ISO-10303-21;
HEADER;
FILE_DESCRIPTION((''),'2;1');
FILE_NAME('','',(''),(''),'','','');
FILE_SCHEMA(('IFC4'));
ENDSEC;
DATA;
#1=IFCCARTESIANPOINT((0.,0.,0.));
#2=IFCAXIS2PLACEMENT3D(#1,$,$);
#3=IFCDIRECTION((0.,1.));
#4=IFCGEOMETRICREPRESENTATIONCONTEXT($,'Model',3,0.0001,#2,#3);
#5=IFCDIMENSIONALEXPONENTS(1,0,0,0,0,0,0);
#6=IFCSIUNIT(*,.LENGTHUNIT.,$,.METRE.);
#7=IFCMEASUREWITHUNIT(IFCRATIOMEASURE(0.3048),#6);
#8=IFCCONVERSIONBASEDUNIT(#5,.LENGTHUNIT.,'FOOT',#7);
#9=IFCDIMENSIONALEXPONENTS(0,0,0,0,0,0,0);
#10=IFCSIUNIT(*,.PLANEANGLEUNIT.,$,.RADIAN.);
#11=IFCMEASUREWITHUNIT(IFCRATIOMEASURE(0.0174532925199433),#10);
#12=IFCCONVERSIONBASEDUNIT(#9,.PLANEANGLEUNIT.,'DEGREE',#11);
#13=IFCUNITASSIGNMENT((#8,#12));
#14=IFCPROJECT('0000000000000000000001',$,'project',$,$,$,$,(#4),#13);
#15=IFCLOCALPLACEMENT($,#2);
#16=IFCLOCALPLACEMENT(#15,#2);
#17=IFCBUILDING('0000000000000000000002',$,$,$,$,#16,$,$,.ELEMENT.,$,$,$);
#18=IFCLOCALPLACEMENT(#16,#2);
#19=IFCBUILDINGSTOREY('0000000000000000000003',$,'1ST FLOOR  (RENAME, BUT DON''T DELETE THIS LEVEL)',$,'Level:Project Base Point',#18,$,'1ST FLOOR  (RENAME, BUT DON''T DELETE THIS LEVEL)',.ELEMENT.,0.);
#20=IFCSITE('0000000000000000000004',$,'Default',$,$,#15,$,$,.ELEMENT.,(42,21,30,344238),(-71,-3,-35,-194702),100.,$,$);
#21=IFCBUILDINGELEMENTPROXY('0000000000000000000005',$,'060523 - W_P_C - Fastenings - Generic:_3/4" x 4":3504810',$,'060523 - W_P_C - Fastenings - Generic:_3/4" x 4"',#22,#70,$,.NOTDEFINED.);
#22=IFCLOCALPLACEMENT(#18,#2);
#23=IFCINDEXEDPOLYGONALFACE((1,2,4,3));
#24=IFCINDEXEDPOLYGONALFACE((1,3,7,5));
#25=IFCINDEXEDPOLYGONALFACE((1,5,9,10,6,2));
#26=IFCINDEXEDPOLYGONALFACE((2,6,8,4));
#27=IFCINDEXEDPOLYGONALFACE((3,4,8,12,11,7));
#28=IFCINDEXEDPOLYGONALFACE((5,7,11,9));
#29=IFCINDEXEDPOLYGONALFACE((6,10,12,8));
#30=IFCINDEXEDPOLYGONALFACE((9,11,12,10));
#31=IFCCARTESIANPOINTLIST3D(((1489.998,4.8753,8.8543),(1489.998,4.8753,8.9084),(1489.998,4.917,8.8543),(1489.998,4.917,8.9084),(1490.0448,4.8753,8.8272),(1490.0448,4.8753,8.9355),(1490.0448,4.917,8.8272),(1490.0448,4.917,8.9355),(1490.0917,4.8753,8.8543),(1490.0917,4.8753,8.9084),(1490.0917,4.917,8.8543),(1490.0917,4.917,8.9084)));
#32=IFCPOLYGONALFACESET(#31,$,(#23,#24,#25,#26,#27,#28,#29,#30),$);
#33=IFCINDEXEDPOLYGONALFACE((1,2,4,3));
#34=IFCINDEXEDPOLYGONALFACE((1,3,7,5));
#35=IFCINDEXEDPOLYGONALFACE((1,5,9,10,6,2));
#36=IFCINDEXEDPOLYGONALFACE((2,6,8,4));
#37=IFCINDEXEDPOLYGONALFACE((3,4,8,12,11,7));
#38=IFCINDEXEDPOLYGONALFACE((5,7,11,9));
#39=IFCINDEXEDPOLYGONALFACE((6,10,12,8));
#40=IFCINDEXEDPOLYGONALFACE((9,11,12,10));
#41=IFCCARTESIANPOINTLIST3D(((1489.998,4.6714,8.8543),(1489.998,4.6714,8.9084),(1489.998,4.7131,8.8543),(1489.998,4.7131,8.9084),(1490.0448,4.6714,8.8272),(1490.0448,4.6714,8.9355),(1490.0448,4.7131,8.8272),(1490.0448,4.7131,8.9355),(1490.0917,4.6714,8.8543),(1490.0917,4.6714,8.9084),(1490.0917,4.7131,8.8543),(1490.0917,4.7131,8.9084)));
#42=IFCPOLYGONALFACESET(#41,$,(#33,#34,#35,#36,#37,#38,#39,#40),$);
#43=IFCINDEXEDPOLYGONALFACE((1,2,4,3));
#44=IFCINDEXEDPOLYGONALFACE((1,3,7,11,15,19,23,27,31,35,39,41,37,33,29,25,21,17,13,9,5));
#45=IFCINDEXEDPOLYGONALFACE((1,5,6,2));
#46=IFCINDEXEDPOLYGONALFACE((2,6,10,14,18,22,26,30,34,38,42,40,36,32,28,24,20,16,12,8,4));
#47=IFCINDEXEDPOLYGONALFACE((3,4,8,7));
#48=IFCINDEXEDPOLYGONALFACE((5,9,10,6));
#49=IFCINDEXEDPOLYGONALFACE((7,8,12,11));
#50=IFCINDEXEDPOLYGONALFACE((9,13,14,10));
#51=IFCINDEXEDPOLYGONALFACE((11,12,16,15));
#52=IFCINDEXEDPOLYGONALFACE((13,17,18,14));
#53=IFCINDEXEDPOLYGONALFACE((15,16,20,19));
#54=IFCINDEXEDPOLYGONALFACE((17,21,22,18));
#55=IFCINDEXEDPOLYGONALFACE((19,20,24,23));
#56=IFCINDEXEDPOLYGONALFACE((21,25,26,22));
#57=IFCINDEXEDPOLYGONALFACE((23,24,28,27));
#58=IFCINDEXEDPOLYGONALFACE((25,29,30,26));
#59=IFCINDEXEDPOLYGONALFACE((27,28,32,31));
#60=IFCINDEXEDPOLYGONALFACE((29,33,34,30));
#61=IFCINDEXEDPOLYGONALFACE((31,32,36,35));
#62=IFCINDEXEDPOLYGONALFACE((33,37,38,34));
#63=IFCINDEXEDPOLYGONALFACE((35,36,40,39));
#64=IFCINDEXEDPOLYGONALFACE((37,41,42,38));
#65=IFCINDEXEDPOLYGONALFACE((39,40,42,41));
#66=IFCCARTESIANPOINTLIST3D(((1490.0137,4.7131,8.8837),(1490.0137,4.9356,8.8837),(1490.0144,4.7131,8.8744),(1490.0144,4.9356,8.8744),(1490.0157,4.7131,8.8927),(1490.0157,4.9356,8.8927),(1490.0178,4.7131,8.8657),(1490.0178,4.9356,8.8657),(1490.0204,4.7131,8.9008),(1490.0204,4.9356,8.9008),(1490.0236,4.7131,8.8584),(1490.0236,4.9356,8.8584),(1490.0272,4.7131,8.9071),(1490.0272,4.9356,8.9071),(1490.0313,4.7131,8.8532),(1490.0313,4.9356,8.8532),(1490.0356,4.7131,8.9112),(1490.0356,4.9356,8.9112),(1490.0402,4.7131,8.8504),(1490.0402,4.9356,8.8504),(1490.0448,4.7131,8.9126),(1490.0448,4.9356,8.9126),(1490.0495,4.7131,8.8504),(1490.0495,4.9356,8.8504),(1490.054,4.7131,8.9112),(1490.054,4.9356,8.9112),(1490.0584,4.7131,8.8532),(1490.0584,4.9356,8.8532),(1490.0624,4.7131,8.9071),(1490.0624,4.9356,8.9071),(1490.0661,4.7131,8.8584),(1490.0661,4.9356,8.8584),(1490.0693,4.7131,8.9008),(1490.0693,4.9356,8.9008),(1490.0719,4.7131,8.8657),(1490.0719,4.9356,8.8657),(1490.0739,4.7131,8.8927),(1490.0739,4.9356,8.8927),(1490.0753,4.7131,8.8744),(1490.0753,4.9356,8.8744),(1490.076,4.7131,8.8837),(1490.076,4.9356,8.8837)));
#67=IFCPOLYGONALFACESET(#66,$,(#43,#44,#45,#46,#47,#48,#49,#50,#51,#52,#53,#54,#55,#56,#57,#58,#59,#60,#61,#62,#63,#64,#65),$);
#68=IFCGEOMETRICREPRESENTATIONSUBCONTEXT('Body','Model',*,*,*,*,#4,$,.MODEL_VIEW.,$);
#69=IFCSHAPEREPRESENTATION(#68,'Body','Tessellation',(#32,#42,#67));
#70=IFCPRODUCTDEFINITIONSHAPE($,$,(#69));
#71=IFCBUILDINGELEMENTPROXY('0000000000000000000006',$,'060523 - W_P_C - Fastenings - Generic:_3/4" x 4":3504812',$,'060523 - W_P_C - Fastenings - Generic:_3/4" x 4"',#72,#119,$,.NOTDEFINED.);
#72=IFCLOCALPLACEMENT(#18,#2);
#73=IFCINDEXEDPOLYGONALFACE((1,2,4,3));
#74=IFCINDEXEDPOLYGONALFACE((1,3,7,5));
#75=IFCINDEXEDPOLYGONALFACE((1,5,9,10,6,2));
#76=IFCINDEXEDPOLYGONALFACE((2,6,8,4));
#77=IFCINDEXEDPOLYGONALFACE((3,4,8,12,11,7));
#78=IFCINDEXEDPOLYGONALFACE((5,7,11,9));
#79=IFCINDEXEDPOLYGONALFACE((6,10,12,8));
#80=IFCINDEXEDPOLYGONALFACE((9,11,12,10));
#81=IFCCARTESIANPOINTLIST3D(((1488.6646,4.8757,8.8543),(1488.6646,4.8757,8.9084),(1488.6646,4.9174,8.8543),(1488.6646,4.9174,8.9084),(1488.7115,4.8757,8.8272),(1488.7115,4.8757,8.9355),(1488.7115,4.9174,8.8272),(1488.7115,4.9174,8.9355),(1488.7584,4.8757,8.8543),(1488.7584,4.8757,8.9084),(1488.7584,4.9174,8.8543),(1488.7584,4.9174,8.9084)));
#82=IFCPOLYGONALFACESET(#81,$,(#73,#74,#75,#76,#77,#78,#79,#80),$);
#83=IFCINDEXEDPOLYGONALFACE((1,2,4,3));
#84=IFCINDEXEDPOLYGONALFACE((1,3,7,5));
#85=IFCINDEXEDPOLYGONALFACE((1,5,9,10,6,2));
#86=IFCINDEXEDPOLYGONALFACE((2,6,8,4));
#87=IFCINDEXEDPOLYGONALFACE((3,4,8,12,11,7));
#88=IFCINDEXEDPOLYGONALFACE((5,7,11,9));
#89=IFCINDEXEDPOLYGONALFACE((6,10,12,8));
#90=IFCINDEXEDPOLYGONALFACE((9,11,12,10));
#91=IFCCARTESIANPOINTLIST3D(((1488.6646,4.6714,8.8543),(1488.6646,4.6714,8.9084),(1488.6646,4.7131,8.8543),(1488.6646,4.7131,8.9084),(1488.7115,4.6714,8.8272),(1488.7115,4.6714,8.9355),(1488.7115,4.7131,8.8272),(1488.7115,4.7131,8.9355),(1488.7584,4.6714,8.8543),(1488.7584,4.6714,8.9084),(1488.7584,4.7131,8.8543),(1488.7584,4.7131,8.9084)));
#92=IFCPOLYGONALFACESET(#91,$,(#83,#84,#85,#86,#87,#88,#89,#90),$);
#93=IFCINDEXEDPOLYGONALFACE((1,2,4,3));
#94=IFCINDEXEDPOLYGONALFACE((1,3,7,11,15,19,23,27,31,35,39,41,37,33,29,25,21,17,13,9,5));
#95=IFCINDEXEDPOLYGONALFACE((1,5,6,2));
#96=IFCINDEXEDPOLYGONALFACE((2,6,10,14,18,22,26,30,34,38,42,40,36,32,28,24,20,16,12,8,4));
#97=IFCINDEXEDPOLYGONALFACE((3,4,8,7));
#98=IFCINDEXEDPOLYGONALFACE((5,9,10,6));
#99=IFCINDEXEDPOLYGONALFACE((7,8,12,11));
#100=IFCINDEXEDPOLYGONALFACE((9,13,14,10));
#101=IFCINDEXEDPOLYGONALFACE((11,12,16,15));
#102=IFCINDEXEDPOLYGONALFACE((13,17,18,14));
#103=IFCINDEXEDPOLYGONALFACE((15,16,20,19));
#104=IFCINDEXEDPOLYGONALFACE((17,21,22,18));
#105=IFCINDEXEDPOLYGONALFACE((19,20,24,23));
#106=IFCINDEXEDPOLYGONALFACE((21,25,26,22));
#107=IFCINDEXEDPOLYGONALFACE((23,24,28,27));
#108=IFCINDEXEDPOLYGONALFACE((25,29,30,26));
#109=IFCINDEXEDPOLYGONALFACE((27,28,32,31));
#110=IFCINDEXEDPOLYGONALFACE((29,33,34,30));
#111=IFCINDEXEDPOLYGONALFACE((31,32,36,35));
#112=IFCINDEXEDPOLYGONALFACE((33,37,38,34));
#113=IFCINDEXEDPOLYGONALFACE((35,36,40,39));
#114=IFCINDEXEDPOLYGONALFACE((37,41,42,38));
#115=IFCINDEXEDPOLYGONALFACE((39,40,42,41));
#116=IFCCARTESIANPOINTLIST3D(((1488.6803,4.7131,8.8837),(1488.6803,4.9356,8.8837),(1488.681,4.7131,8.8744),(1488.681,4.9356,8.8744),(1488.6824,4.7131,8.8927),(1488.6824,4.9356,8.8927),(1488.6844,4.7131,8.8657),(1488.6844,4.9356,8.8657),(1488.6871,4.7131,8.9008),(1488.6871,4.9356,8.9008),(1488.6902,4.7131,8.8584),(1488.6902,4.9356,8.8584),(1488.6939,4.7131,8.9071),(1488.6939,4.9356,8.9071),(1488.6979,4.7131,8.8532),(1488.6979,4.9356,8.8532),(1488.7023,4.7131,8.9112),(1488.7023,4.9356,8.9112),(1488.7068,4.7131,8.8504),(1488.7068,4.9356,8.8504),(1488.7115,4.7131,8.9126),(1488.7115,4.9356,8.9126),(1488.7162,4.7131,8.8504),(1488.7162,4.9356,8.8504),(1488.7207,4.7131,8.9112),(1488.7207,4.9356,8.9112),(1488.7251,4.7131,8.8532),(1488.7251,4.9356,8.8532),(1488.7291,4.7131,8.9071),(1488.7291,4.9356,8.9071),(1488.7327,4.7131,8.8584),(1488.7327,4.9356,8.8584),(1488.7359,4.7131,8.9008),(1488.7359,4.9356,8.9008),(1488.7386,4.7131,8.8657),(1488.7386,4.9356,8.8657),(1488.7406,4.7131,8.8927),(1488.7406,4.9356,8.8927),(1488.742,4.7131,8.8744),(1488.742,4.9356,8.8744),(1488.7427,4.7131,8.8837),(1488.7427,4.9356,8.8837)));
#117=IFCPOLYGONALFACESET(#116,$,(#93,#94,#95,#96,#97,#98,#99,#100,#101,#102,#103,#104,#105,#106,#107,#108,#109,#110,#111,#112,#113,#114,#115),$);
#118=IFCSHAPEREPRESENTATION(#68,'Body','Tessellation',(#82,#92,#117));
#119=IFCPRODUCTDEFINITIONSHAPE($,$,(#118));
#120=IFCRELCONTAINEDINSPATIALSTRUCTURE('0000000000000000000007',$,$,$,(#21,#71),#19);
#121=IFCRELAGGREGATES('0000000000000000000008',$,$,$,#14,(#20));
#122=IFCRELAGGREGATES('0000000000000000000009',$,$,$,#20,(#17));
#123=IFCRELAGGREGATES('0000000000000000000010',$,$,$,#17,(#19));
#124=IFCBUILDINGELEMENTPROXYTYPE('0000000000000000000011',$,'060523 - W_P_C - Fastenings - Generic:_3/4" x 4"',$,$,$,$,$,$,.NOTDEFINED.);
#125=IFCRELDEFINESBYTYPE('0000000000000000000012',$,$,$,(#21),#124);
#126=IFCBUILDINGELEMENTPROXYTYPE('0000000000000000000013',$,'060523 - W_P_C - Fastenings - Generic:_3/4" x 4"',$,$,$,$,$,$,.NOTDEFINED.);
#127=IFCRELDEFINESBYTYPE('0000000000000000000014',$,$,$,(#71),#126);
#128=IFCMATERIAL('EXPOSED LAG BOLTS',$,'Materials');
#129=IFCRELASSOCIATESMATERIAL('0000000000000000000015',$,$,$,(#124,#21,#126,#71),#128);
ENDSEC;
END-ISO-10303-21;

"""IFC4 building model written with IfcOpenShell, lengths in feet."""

from ifc_helpers import new_model, entity, si_unit, converted_unit, direction, frame, frame_2d, origin, place, context, subcontext, project, spatial, polyline, circle, outline, extrude, source, transform, mapped, material, type_object, type_shapes, element, save


model = new_model("IFC4")

# Units and contexts
model_context = context("Model", 3, precision=0.0001, world=origin(), true_north=direction((0.0, 1.0)))
body_context = subcontext(model_context, "Body", "Model", "MODEL_VIEW")
ifc_project = project(units=[converted_unit("LENGTHUNIT", "FOOT", entity("IfcRatioMeasure", 0.3048), si_unit("LENGTHUNIT", "METRE"), dimensions=[1, 0, 0, 0, 0, 0, 0]), converted_unit("PLANEANGLEUNIT", "DEGREE", entity("IfcRatioMeasure", 0.0174532925199433), si_unit("PLANEANGLEUNIT", "RADIAN"), dimensions=[0, 0, 0, 0, 0, 0, 0])], contexts=[model_context])

# Site, building, storey
site_placement = place(None, origin())
site = spatial("IfcSite", under=ifc_project, at=site_placement, Name="Default", CompositionType="ELEMENT", RefLatitude=(42, 21, 30, 344238), RefLongitude=(-71, -3, -35, -194702), RefElevation=100.0)
building_placement = place(site_placement, origin())
building = spatial("IfcBuilding", under=site, at=building_placement, CompositionType="ELEMENT")
storey_placement = place(building_placement, origin())
storey = spatial("IfcBuildingStorey", under=building, at=storey_placement, Name="1ST FLOOR  (RENAME, BUT DON'T DELETE THIS LEVEL)", ObjectType="Level:Project Base Point", LongName="1ST FLOOR  (RENAME, BUT DON'T DELETE THIS LEVEL)", CompositionType="ELEMENT", Elevation=0.0)

# Building element proxies
ifc_material_1 = material(Name="EXPOSED LAG BOLTS", Category="Materials")
building_element_proxy_type_1 = type_object("IfcBuildingElementProxyType", Name="060523 - W_P_C - Fastenings - Generic:_3/4\" x 4\"", PredefinedType="NOTDEFINED", material=ifc_material_1)
shared_shape_1 = source(origin(), body_context, "Body", "SweptSolid", [
    extrude(outline(polyline([(-0.0271, -0.0469), (0.0271, -0.0469), (0.0541, 0.0), (0.0271, 0.0469), (-0.0271, 0.0469), (-0.0541, 0.0), (-0.0271, -0.0469)])), frame((0.0, 0.0, -0.204), z_axis=(0.0, 0.0, 1.0), x_axis=(0.866025, -0.5, 0.0)), (0.0, 0.0, 1.0), 0.0417),
    extrude(outline(polyline([(-0.0271, -0.0469), (0.0271, -0.0469), (0.0541, 0.0), (0.0271, 0.0469), (-0.0271, 0.0469), (-0.0541, 0.0), (-0.0271, -0.0469)])), frame((0.0, 0.0, 0.0), z_axis=(0.0, 0.0, 1.0), x_axis=(0.0, -1.0, 0.0)), (0.0, 0.0, 1.0), 0.0417),
    extrude(circle(Radius=0.0312, at=frame_2d((0.0, 0.0), x_axis=(1.0, 0.0))), frame((0.0, 0.0, -0.2226), z_axis=(0.0, 0.0, 1.0), x_axis=(0.0, 1.0, 0.0)), (0.0, 0.0, 1.0), 0.2226),
])
type_shapes(building_element_proxy_type_1, [shared_shape_1])
proxy_1_placement = place(storey_placement, frame((1490.0448, 4.7131, 8.8813), z_axis=(0.0, -1.0, 0.0), x_axis=(1.0, 0.0, 0.0)))
element("IfcBuildingElementProxy", 1, at=proxy_1_placement, inside=storey, type_object=building_element_proxy_type_1, material=ifc_material_1, Name="060523 - W_P_C - Fastenings - Generic:_3/4\" x 4\":3504810", ObjectType="060523 - W_P_C - Fastenings - Generic:_3/4\" x 4\"", PredefinedType="NOTDEFINED", context=body_context, shape_type="MappedRepresentation", body=[
    mapped(shared_shape_1, transform((0.0, 0.0, 0.0), scale=1.0)),
])
building_element_proxy_type_2 = type_object("IfcBuildingElementProxyType", Name="060523 - W_P_C - Fastenings - Generic:_3/4\" x 4\"", PredefinedType="NOTDEFINED", material=ifc_material_1)
shared_shape_2 = source(origin(), body_context, "Body", "SweptSolid", [
    extrude(outline(polyline([(-0.0271, -0.0469), (0.0271, -0.0469), (0.0541, 0.0), (0.0271, 0.0469), (-0.0271, 0.0469), (-0.0541, 0.0), (-0.0271, -0.0469)])), frame((0.0, 0.0, -0.2043), z_axis=(0.0, 0.0, 1.0), x_axis=(0.866025, -0.5, 0.0)), (0.0, 0.0, 1.0), 0.0417),
    extrude(outline(polyline([(-0.0271, -0.0469), (0.0271, -0.0469), (0.0541, 0.0), (0.0271, 0.0469), (-0.0271, 0.0469), (-0.0541, 0.0), (-0.0271, -0.0469)])), frame((0.0, 0.0, 0.0), z_axis=(0.0, 0.0, 1.0), x_axis=(0.0, -1.0, 0.0)), (0.0, 0.0, 1.0), 0.0417),
    extrude(circle(Radius=0.0312, at=frame_2d((0.0, 0.0), x_axis=(1.0, 0.0))), frame((0.0, 0.0, -0.2226), z_axis=(0.0, 0.0, 1.0), x_axis=(0.0, 1.0, 0.0)), (0.0, 0.0, 1.0), 0.2226),
])
type_shapes(building_element_proxy_type_2, [shared_shape_2])
proxy_2_placement = place(storey_placement, frame((1488.7115, 4.7131, 8.8813), z_axis=(0.0, -1.0, 0.0), x_axis=(1.0, 0.0, 0.0)))
element("IfcBuildingElementProxy", 2, at=proxy_2_placement, inside=storey, type_object=building_element_proxy_type_2, material=ifc_material_1, Name="060523 - W_P_C - Fastenings - Generic:_3/4\" x 4\":3504812", ObjectType="060523 - W_P_C - Fastenings - Generic:_3/4\" x 4\"", PredefinedType="NOTDEFINED", context=body_context, shape_type="MappedRepresentation", body=[
    mapped(shared_shape_2, transform((0.0, 0.0, 0.0), scale=1.0)),
])

save(model, "model.ifc")
